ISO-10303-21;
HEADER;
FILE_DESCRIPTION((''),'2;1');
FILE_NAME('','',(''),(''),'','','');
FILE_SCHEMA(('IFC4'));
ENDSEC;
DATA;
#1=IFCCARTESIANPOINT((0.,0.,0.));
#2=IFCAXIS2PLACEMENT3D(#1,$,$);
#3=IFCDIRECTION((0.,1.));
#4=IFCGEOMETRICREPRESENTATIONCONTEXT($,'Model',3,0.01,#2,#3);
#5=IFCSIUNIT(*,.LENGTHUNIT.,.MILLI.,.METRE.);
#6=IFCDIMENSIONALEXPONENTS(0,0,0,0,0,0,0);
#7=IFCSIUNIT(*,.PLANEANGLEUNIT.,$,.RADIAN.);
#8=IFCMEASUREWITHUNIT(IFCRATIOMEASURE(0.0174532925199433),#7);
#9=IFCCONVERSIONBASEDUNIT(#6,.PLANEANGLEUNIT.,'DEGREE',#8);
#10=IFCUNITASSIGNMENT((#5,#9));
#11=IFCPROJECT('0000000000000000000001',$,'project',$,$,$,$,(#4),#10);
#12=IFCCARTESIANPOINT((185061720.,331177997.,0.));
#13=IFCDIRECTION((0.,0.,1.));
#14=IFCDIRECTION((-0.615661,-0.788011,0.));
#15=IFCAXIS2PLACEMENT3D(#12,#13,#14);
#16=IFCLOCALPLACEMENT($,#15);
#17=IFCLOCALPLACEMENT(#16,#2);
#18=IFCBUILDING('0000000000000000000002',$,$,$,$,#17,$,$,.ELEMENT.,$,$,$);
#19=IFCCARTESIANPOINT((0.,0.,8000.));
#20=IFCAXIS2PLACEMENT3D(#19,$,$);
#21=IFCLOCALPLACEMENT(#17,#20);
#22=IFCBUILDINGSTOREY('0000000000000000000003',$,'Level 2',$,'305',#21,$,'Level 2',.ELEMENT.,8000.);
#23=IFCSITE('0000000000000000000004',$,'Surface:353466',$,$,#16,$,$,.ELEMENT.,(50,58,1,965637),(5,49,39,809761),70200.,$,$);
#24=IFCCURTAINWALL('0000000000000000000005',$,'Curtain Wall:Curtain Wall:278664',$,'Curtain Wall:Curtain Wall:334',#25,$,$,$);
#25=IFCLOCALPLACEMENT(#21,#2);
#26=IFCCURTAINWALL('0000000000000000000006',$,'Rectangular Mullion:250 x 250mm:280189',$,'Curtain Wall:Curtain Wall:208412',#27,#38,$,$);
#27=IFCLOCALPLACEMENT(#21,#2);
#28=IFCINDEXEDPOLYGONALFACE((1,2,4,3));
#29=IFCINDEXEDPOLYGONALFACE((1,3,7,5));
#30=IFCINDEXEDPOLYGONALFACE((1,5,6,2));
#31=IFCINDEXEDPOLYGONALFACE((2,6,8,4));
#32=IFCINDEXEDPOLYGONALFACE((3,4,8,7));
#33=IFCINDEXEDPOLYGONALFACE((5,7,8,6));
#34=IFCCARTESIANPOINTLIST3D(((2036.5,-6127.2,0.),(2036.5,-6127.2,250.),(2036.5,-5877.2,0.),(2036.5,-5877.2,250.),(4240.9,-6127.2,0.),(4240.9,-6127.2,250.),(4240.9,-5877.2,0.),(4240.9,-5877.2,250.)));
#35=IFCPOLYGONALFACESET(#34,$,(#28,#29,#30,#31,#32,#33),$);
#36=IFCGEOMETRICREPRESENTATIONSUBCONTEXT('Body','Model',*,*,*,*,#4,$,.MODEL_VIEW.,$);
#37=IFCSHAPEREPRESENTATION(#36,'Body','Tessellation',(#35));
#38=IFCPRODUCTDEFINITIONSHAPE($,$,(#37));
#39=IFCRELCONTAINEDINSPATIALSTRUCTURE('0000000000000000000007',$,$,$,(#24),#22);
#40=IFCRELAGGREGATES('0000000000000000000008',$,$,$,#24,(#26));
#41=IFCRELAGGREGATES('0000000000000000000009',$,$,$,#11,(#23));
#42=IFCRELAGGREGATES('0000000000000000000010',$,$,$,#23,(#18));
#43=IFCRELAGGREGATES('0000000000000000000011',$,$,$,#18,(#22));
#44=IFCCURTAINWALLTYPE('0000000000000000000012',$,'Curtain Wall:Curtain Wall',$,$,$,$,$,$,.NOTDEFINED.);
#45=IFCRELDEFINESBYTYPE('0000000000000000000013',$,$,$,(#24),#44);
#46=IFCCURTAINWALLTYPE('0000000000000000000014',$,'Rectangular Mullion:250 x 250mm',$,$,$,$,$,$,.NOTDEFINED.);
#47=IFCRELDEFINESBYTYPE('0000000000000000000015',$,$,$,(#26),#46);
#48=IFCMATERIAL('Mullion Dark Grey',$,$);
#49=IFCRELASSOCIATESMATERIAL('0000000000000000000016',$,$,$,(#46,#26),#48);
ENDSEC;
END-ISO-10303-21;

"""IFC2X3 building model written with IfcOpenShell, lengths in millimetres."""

from ifc_helpers import new_model, entity, si_unit, converted_unit, direction, frame, origin, origin_2d_with_axis, place, context, subcontext, project, spatial, rectangle, extrude, source, transform, mapped, material, type_object, type_shapes, element, aggregate, save


model = new_model("IFC2X3")

# Units and contexts
model_context = context("Model", 3, precision=0.01, world=origin(), true_north=direction((0.0, 1.0)))
body_context = subcontext(model_context, "Body", "Model", "MODEL_VIEW")
ifc_project = project(units=[si_unit("LENGTHUNIT", "METRE", prefix="MILLI"), converted_unit("PLANEANGLEUNIT", "DEGREE", entity("IfcRatioMeasure", 0.0174532925199433), si_unit("PLANEANGLEUNIT", "RADIAN"), dimensions=[0, 0, 0, 0, 0, 0, 0])], contexts=[model_context])

# Site, building, storey
site_placement = place(None, frame((185061720.0, 331177997.0, 0.0), z_axis=(0.0, 0.0, 1.0), x_axis=(-0.615661, -0.788011, 0.0)))
site = spatial("IfcSite", under=ifc_project, at=site_placement, Name="Surface:353466", CompositionType="ELEMENT", RefLatitude=(50, 58, 1, 965637), RefLongitude=(5, 49, 39, 809761), RefElevation=70200.0)
building_placement = place(site_placement, origin())
building = spatial("IfcBuilding", under=site, at=building_placement, CompositionType="ELEMENT")
storey_placement = place(building_placement, frame((0.0, 0.0, 8000.0)))
storey = spatial("IfcBuildingStorey", under=building, at=storey_placement, Name="Level 2", ObjectType="305", LongName="Level 2", CompositionType="ELEMENT", Elevation=8000.0)

# Curtain walls
curtain_wall_type_1 = type_object("IfcCurtainWallType", Name="Curtain Wall:Curtain Wall", PredefinedType="NOTDEFINED")
curtain_wall_1_placement = place(storey_placement, frame((0.0, 0.0, -8000.0)))
curtain_wall_1 = element("IfcCurtainWall", 1, at=curtain_wall_1_placement, inside=storey, type_object=curtain_wall_type_1, Name="Curtain Wall:Curtain Wall:278664", ObjectType="Curtain Wall:Curtain Wall:334")
ifc_material_1 = material(Name="Mullion Dark Grey")
curtain_wall_type_2 = type_object("IfcCurtainWallType", Name="Rectangular Mullion:250 x 250mm", PredefinedType="NOTDEFINED", material=ifc_material_1)
shared_shape_1 = source(origin(), body_context, "Body", "SweptSolid", [
    extrude(rectangle(XDim=250.0, YDim=250.0, at=origin_2d_with_axis()), frame((-125.0, 0.0, -2204.4), z_axis=(0.0, 0.0, 1.0), x_axis=(-1.0, 0.0, 0.0)), (0.0, 0.0, 1.0), 2204.4),
])
type_shapes(curtain_wall_type_2, [shared_shape_1])
curtain_wall_2_placement = place(storey_placement, frame((2036.5, -6002.2, 0.0), z_axis=(-1.0, 0.0, 0.0), x_axis=(0.0, 0.0, -1.0)))
curtain_wall_2 = element("IfcCurtainWall", 2, at=curtain_wall_2_placement, type_object=curtain_wall_type_2, material=ifc_material_1, Name="Rectangular Mullion:250 x 250mm:280189", ObjectType="Curtain Wall:Curtain Wall:208412", context=body_context, shape_type="MappedRepresentation", body=[
    mapped(shared_shape_1, transform((0.0, 0.0, 0.0), scale=1.0)),
])
aggregate(curtain_wall_1, [curtain_wall_2])

save(model, "model.ifc")
